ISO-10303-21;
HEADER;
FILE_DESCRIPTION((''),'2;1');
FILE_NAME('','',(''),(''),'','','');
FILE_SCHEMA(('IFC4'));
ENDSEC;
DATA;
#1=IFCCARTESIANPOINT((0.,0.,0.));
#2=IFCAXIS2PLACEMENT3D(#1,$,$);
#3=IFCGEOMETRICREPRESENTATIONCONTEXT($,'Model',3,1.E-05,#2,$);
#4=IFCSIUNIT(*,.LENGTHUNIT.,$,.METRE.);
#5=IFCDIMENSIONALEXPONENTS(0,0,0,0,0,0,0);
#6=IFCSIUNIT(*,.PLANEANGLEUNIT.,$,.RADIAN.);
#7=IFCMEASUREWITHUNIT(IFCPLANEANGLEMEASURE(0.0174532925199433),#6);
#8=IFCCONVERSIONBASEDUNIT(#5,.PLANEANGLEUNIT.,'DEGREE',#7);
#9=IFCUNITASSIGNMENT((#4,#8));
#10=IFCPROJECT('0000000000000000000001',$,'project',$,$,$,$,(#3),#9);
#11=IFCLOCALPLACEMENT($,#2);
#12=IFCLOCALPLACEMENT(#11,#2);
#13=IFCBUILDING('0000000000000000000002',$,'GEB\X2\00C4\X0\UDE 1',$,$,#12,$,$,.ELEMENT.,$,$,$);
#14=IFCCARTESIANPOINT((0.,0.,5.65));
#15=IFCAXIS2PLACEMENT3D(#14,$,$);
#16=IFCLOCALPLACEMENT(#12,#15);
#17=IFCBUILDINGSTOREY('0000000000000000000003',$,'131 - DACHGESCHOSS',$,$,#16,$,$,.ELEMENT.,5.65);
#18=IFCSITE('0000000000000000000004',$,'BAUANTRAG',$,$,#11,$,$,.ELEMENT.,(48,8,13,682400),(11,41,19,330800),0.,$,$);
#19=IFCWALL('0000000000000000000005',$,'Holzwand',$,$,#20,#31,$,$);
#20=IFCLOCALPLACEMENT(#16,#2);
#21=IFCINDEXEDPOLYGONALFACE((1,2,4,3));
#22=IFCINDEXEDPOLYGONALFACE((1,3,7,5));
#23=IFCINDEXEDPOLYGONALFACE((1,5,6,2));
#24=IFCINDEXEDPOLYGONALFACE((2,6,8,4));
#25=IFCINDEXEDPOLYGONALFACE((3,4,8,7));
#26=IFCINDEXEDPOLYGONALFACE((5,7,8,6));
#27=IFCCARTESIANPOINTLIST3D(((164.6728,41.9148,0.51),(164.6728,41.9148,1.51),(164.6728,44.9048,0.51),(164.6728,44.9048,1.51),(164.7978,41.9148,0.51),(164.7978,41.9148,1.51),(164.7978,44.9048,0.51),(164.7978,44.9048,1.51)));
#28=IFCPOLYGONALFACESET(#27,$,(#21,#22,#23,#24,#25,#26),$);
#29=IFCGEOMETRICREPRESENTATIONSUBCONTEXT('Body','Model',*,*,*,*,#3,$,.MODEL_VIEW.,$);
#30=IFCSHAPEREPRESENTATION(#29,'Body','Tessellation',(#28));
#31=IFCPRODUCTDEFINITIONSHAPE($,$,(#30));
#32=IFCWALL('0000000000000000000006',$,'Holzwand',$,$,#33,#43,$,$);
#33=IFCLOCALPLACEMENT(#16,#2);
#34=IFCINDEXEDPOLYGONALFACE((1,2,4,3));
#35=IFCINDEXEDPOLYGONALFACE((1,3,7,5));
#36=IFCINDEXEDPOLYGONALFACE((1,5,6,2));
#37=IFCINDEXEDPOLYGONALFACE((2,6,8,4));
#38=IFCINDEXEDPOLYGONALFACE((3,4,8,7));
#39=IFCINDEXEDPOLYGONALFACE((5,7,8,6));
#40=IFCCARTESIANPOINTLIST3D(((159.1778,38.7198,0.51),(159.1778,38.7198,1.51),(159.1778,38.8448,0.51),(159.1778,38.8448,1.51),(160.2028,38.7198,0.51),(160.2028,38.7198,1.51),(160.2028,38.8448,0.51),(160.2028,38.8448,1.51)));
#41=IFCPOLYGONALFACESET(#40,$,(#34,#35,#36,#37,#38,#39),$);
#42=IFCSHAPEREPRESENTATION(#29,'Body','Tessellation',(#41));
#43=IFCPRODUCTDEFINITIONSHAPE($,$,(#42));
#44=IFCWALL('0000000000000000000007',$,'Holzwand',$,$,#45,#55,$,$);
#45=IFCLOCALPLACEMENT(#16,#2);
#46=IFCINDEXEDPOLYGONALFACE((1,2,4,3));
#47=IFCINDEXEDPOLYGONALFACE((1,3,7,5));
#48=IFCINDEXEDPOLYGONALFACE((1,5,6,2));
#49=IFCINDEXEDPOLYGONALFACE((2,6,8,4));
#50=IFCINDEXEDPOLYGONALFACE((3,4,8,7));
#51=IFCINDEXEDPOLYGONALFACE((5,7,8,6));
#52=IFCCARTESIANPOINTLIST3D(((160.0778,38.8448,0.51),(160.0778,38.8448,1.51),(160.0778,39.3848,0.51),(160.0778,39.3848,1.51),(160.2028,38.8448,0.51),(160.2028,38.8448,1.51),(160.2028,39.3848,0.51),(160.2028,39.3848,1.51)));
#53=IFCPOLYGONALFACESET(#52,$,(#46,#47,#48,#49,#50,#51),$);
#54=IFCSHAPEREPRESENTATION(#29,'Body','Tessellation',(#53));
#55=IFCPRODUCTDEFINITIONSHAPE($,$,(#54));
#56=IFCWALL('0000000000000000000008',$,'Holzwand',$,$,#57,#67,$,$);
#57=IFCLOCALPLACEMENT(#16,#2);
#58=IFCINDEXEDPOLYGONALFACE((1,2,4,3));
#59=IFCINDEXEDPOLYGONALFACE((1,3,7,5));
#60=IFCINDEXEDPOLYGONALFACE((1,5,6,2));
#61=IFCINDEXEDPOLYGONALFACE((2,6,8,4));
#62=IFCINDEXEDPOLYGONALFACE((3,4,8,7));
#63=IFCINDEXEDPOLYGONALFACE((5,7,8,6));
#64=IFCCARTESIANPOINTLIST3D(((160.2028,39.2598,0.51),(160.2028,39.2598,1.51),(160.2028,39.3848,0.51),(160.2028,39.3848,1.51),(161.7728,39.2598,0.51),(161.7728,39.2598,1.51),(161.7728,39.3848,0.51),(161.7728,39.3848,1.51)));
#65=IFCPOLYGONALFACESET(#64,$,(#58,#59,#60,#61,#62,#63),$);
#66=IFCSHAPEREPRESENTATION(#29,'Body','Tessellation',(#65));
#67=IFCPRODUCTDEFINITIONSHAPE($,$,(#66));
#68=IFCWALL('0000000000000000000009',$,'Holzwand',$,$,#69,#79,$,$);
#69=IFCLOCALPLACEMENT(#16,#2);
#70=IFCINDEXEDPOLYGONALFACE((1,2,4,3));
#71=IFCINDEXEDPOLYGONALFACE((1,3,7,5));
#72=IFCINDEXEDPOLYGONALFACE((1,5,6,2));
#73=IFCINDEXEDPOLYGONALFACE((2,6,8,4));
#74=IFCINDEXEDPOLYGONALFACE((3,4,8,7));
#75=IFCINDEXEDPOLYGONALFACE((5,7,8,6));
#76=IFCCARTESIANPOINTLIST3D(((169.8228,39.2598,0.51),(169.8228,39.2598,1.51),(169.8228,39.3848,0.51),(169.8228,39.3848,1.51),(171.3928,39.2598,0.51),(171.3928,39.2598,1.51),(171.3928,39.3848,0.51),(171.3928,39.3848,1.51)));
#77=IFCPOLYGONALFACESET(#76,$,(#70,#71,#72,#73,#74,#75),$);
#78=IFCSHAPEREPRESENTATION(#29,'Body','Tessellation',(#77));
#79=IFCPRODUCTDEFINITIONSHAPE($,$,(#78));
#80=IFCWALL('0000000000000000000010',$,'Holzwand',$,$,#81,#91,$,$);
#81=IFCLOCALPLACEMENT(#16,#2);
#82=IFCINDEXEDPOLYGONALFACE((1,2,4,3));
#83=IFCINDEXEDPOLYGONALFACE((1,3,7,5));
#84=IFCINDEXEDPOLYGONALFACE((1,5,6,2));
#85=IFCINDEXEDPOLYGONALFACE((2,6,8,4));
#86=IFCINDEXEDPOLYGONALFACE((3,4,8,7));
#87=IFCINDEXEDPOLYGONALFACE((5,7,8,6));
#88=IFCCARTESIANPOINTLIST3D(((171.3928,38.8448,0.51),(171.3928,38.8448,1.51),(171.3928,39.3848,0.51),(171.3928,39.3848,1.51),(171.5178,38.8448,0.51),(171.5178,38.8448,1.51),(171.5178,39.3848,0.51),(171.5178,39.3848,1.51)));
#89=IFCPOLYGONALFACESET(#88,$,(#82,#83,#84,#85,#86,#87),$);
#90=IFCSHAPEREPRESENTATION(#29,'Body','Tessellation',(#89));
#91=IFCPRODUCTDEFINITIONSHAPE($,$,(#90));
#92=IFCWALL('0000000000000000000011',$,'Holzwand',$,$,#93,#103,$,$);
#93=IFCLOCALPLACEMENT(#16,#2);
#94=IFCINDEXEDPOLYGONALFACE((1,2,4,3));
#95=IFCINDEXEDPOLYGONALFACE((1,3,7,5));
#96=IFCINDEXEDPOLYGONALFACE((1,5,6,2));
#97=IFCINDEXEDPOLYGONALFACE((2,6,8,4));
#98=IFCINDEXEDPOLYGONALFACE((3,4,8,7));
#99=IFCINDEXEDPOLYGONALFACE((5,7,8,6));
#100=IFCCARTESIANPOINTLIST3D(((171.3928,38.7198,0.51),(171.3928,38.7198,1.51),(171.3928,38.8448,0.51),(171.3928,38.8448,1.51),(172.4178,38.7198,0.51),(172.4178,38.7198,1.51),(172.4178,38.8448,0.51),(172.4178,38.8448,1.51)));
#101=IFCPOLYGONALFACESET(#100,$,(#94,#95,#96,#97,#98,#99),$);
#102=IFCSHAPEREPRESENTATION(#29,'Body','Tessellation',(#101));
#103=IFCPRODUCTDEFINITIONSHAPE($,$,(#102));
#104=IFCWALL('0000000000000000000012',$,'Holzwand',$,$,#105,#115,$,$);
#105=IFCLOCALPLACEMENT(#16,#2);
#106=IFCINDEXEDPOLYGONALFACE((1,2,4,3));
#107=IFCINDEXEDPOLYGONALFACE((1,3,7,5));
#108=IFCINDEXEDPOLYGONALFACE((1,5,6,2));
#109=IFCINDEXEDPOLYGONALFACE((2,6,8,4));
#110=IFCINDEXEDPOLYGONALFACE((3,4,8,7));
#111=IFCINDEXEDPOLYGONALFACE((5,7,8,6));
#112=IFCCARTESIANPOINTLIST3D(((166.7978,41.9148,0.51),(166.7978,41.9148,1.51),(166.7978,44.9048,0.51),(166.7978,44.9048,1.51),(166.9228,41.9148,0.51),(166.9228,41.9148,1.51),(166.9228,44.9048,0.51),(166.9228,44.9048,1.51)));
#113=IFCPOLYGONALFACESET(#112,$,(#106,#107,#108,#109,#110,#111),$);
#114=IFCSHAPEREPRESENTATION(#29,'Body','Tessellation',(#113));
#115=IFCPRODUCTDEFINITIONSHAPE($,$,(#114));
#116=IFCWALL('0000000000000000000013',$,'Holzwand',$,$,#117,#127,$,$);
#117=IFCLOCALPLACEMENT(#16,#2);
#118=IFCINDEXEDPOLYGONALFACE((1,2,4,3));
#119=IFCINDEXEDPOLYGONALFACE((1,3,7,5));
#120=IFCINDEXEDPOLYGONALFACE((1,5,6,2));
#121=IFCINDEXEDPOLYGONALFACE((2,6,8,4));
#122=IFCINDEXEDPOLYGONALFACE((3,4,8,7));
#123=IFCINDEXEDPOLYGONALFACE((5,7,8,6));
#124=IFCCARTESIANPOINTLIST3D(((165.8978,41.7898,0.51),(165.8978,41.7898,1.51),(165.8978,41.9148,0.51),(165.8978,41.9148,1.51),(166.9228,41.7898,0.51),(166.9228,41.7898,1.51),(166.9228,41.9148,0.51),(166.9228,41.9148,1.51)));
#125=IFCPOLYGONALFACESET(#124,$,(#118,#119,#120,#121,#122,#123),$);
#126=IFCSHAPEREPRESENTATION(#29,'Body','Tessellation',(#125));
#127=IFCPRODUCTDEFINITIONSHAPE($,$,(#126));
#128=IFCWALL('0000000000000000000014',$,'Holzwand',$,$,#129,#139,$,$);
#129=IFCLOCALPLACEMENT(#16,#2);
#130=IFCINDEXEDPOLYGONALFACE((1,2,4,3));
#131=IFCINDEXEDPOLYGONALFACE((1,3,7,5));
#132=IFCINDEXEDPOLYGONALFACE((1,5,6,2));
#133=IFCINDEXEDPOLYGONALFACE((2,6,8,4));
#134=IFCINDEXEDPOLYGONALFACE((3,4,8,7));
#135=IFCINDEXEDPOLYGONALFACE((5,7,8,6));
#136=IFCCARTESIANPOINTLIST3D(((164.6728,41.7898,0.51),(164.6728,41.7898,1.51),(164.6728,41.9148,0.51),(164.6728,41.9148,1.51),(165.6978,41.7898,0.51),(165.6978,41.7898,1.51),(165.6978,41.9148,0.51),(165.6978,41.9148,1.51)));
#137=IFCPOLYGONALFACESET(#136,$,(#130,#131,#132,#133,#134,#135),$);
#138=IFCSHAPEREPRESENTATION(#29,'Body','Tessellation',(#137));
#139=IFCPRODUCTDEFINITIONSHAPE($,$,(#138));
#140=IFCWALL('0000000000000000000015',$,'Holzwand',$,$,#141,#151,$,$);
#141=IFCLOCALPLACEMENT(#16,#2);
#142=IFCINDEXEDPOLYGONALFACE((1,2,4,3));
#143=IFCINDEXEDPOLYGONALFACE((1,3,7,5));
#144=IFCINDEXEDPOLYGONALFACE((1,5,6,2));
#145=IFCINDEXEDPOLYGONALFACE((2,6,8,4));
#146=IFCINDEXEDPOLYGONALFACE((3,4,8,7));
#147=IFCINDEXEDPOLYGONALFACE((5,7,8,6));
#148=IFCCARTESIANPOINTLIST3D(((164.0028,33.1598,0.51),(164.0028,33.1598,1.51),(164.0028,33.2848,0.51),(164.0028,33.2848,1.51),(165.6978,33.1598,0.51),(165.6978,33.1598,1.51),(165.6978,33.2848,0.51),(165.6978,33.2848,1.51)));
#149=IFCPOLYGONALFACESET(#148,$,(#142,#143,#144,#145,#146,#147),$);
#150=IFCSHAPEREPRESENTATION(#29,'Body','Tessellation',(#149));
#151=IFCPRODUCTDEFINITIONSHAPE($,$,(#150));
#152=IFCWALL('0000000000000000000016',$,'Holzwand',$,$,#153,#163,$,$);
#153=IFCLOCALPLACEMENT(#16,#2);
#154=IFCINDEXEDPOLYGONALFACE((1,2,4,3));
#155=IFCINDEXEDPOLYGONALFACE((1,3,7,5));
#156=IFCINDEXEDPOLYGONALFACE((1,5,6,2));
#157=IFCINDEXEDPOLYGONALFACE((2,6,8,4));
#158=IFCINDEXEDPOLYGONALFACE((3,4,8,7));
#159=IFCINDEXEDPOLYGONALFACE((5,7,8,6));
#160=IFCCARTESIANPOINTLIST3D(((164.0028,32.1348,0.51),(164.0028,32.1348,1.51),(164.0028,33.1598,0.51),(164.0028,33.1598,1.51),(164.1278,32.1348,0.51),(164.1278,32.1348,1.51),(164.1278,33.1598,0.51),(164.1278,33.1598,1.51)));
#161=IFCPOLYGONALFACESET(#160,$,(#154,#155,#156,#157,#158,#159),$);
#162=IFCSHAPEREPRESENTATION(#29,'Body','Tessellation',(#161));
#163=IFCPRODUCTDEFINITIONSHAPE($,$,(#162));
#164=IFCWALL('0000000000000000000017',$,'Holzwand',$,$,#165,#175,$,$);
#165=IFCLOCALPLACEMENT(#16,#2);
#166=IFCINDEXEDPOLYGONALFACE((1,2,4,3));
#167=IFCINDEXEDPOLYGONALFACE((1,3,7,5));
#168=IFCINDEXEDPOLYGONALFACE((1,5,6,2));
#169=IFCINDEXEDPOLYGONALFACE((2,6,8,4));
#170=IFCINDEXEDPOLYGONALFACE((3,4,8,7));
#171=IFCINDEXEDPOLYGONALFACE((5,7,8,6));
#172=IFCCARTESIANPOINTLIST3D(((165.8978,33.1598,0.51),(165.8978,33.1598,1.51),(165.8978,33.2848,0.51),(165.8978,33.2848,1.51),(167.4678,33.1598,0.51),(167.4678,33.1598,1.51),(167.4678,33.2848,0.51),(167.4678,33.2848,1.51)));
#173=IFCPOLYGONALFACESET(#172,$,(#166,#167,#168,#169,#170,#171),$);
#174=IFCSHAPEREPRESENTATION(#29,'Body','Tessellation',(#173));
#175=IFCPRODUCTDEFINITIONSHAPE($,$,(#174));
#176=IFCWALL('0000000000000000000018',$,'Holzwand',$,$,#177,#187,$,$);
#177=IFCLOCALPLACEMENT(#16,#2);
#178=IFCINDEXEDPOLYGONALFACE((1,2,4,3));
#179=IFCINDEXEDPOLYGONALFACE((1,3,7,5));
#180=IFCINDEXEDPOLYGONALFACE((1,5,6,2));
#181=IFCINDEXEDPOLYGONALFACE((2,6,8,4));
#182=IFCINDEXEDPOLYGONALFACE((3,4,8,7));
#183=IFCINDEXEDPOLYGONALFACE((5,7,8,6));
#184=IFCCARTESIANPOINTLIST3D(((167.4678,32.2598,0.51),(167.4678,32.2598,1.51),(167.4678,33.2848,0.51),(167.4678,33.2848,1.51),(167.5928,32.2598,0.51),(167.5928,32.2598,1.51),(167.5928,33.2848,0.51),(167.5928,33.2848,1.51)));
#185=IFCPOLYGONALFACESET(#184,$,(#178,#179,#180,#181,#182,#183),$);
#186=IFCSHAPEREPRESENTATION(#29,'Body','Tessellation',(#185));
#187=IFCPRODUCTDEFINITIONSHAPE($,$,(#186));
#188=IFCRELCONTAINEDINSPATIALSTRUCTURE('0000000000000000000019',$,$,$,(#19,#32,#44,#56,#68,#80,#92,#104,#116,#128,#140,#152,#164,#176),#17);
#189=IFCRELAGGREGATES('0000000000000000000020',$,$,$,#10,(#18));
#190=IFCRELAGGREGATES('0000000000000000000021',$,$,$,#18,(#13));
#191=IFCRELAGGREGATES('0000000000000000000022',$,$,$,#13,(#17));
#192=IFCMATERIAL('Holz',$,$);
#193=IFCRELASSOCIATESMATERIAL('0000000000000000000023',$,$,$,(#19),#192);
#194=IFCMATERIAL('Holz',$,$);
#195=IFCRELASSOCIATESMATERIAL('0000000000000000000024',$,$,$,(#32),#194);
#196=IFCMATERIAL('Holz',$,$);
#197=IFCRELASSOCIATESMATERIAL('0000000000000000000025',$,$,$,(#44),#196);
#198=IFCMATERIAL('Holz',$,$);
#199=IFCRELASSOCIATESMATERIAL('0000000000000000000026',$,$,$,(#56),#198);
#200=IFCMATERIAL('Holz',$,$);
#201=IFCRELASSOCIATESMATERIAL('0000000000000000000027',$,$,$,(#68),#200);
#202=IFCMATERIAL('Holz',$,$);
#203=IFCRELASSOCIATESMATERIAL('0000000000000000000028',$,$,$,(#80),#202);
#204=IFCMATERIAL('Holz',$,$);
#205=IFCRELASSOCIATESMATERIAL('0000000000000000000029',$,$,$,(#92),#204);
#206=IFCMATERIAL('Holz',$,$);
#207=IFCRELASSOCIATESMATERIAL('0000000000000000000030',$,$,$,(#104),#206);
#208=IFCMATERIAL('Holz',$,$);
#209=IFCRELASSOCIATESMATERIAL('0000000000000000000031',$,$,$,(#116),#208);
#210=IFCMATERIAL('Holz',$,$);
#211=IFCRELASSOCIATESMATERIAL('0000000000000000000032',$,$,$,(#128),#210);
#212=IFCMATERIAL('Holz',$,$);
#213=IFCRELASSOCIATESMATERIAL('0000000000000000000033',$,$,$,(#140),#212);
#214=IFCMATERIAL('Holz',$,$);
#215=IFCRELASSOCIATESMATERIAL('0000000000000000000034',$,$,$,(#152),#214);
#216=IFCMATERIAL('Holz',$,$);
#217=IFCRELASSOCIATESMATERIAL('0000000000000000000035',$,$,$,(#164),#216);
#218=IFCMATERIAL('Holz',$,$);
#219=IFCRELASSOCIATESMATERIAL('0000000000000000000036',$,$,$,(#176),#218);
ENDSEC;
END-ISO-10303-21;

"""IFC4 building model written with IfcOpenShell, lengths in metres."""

from ifc_helpers import new_model, entity, si_unit, converted_unit, frame, origin, origin_with_axes, place, context, subcontext, project, spatial, indexed_curve, outline, extrude, material, element, save


model = new_model("IFC4")

# Units and contexts
model_context = context("Model", 3, precision=1e-05, world=origin())
body_context = subcontext(model_context, "Body", "Model", "MODEL_VIEW")
ifc_project = project(units=[si_unit("LENGTHUNIT", "METRE"), converted_unit("PLANEANGLEUNIT", "DEGREE", entity("IfcPlaneAngleMeasure", 0.0174532925199433), si_unit("PLANEANGLEUNIT", "RADIAN"), dimensions=[0, 0, 0, 0, 0, 0, 0])], contexts=[model_context])

# Site, building, storey
site_placement = place(None, origin())
site = spatial("IfcSite", under=ifc_project, at=site_placement, Name="BAUANTRAG", CompositionType="ELEMENT", RefLatitude=(48, 8, 13, 682400), RefLongitude=(11, 41, 19, 330800), RefElevation=0.0)
building_placement = place(site_placement, origin())
building = spatial("IfcBuilding", under=site, at=building_placement, Name="GEBÄUDE 1", CompositionType="ELEMENT")
storey_placement = place(building_placement, frame((0.0, 0.0, 5.65)))
storey = spatial("IfcBuildingStorey", under=building, at=storey_placement, Name="131 - DACHGESCHOSS", CompositionType="ELEMENT", Elevation=5.65)

# Walls
ifc_material_1 = material(Name="Holz")
wall_1_placement = place(storey_placement, frame((164.7978, 41.9148, 0.51), z_axis=(0.0, 0.0, 1.0), x_axis=(0.0, 1.0, 0.0)))
element("IfcWall", 1, at=wall_1_placement, inside=storey, material=ifc_material_1, Name="Holzwand", context=body_context, shape_type="SweptSolid", body=[
    extrude(outline(indexed_curve([(0.0, -0.125), (2.99, -0.125), (2.99, 0.0), (0.0, 0.0), (0.0, -0.125)], self_intersect=False)), frame((0.0, 0.125, 0.0), z_axis=(0.0, 0.0, 1.0), x_axis=(1.0, 0.0, 0.0)), (0.0, 0.0, 1.0), 1.0),
])
ifc_material_2 = material(Name="Holz")
wall_2_placement = place(storey_placement, frame((160.2028, 38.8448, 0.51), z_axis=(0.0, 0.0, 1.0), x_axis=(-1.0, 0.0, 0.0)))
element("IfcWall", 2, at=wall_2_placement, inside=storey, material=ifc_material_2, Name="Holzwand", context=body_context, shape_type="SweptSolid", body=[
    extrude(outline(indexed_curve([(-1.025, -0.125), (0.0, -0.125), (0.0, 0.0), (-1.025, 0.0), (-1.025, -0.125)], self_intersect=False)), frame((1.025, 0.125, 0.0), z_axis=(0.0, 0.0, 1.0), x_axis=(1.0, 0.0, 0.0)), (0.0, 0.0, 1.0), 1.0),
])
ifc_material_3 = material(Name="Holz")
wall_3_placement = place(storey_placement, frame((160.0778, 39.3848, 0.51), z_axis=(0.0, 0.0, 1.0), x_axis=(0.0, -1.0, 0.0)))
element("IfcWall", 3, at=wall_3_placement, inside=storey, material=ifc_material_3, Name="Holzwand", context=body_context, shape_type="SweptSolid", body=[
    extrude(outline(indexed_curve([(-0.54, 0.0), (0.0, 0.0), (0.0, 0.125), (-0.54, 0.125), (-0.54, 0.0)], self_intersect=False)), frame((0.54, 0.0, 0.0), z_axis=(0.0, 0.0, 1.0), x_axis=(1.0, 0.0, 0.0)), (0.0, 0.0, 1.0), 1.0),
])
ifc_material_4 = material(Name="Holz")
wall_4_placement = place(storey_placement, frame((161.7728, 39.3848, 0.51), z_axis=(0.0, 0.0, 1.0), x_axis=(-1.0, 0.0, 0.0)))
element("IfcWall", 4, at=wall_4_placement, inside=storey, material=ifc_material_4, Name="Holzwand", context=body_context, shape_type="SweptSolid", body=[
    extrude(outline(indexed_curve([(-1.57, -0.125), (0.0, -0.125), (0.0, 0.0), (-1.57, 0.0), (-1.57, -0.125)], self_intersect=False)), frame((1.57, 0.125, 0.0), z_axis=(0.0, 0.0, 1.0), x_axis=(1.0, 0.0, 0.0)), (0.0, 0.0, 1.0), 1.0),
])
ifc_material_5 = material(Name="Holz")
wall_5_placement = place(storey_placement, frame((171.3928, 39.3848, 0.51), z_axis=(0.0, 0.0, 1.0), x_axis=(-1.0, 0.0, 0.0)))
element("IfcWall", 5, at=wall_5_placement, inside=storey, material=ifc_material_5, Name="Holzwand", context=body_context, shape_type="SweptSolid", body=[
    extrude(outline(indexed_curve([(-1.57, -0.125), (0.0, -0.125), (0.0, 0.0), (-1.57, 0.0), (-1.57, -0.125)], self_intersect=False)), frame((1.57, 0.125, 0.0), z_axis=(0.0, 0.0, 1.0), x_axis=(1.0, 0.0, 0.0)), (0.0, 0.0, 1.0), 1.0),
])
ifc_material_6 = material(Name="Holz")
wall_6_placement = place(storey_placement, frame((171.5178, 38.8448, 0.51), z_axis=(0.0, 0.0, 1.0), x_axis=(0.0, 1.0, 0.0)))
element("IfcWall", 6, at=wall_6_placement, inside=storey, material=ifc_material_6, Name="Holzwand", context=body_context, shape_type="SweptSolid", body=[
    extrude(outline(indexed_curve([(0.0, -0.125), (0.54, -0.125), (0.54, 0.0), (0.0, 0.0), (0.0, -0.125)], self_intersect=False)), frame((0.0, 0.125, 0.0), z_axis=(0.0, 0.0, 1.0), x_axis=(1.0, 0.0, 0.0)), (0.0, 0.0, 1.0), 1.0),
])
ifc_material_7 = material(Name="Holz")
wall_7_placement = place(storey_placement, frame((172.4178, 38.8448, 0.51), z_axis=(0.0, 0.0, 1.0), x_axis=(-1.0, 0.0, 0.0)))
element("IfcWall", 7, at=wall_7_placement, inside=storey, material=ifc_material_7, Name="Holzwand", context=body_context, shape_type="SweptSolid", body=[
    extrude(outline(indexed_curve([(-1.025, -0.125), (0.0, -0.125), (0.0, 0.0), (-1.025, 0.0), (-1.025, -0.125)], self_intersect=False)), frame((1.025, 0.125, 0.0), z_axis=(0.0, 0.0, 1.0), x_axis=(1.0, 0.0, 0.0)), (0.0, 0.0, 1.0), 1.0),
])
ifc_material_8 = material(Name="Holz")
wall_8_placement = place(storey_placement, frame((166.7978, 44.9048, 0.51), z_axis=(0.0, 0.0, 1.0), x_axis=(0.0, -1.0, 0.0)))
element("IfcWall", 8, at=wall_8_placement, inside=storey, material=ifc_material_8, Name="Holzwand", context=body_context, shape_type="SweptSolid", body=[
    extrude(outline(indexed_curve([(-2.99, 0.0), (0.0, 0.0), (0.0, 0.125), (-2.99, 0.125), (-2.99, 0.0)], self_intersect=False)), frame((2.99, 0.0, 0.0), z_axis=(0.0, 0.0, 1.0), x_axis=(1.0, 0.0, 0.0)), (0.0, 0.0, 1.0), 1.0),
])
ifc_material_9 = material(Name="Holz")
wall_9_placement = place(storey_placement, frame((166.9228, 41.9148, 0.51), z_axis=(0.0, 0.0, 1.0), x_axis=(-1.0, 0.0, 0.0)))
element("IfcWall", 9, at=wall_9_placement, inside=storey, material=ifc_material_9, Name="Holzwand", context=body_context, shape_type="SweptSolid", body=[
    extrude(outline(indexed_curve([(-1.025, -0.125), (0.0, -0.125), (0.0, 0.0), (-1.025, 0.0), (-1.025, -0.125)], self_intersect=False)), frame((1.025, 0.125, 0.0), z_axis=(0.0, 0.0, 1.0), x_axis=(1.0, 0.0, 0.0)), (0.0, 0.0, 1.0), 1.0),
])
ifc_material_10 = material(Name="Holz")
wall_10_placement = place(storey_placement, frame((165.6978, 41.9148, 0.51), z_axis=(0.0, 0.0, 1.0), x_axis=(-1.0, 0.0, 0.0)))
element("IfcWall", 10, at=wall_10_placement, inside=storey, material=ifc_material_10, Name="Holzwand", context=body_context, shape_type="SweptSolid", body=[
    extrude(outline(indexed_curve([(-1.025, -0.125), (0.0, -0.125), (0.0, 0.0), (-1.025, 0.0), (-1.025, -0.125)], self_intersect=False)), frame((1.025, 0.125, 0.0), z_axis=(0.0, 0.0, 1.0), x_axis=(1.0, 0.0, 0.0)), (0.0, 0.0, 1.0), 1.0),
])
ifc_material_11 = material(Name="Holz")
wall_11_placement = place(storey_placement, frame((164.0028, 33.1598, 0.51)))
element("IfcWall", 11, at=wall_11_placement, inside=storey, material=ifc_material_11, Name="Holzwand", context=body_context, shape_type="SweptSolid", body=[
    extrude(outline(indexed_curve([(0.0, 0.0), (1.695, 0.0), (1.695, 0.125), (0.0, 0.125), (0.0, 0.0)], self_intersect=False)), origin_with_axes(), (0.0, 0.0, 1.0), 1.0),
])
ifc_material_12 = material(Name="Holz")
wall_12_placement = place(storey_placement, frame((164.1278, 32.1348, 0.51), z_axis=(0.0, 0.0, 1.0), x_axis=(0.0, 1.0, 0.0)))
element("IfcWall", 12, at=wall_12_placement, inside=storey, material=ifc_material_12, Name="Holzwand", context=body_context, shape_type="SweptSolid", body=[
    extrude(outline(indexed_curve([(0.0, -0.125), (1.025, -0.125), (1.025, 0.0), (0.0, 0.0), (0.0, -0.125)], self_intersect=False)), frame((0.0, 0.125, 0.0), z_axis=(0.0, 0.0, 1.0), x_axis=(1.0, 0.0, 0.0)), (0.0, 0.0, 1.0), 1.0),
])
ifc_material_13 = material(Name="Holz")
wall_13_placement = place(storey_placement, frame((165.8978, 33.1598, 0.51)))
element("IfcWall", 13, at=wall_13_placement, inside=storey, material=ifc_material_13, Name="Holzwand", context=body_context, shape_type="SweptSolid", body=[
    extrude(outline(indexed_curve([(0.0, 0.0), (1.57, 0.0), (1.57, 0.125), (0.0, 0.125), (0.0, 0.0)], self_intersect=False)), origin_with_axes(), (0.0, 0.0, 1.0), 1.0),
])
ifc_material_14 = material(Name="Holz")
wall_14_placement = place(storey_placement, frame((167.4678, 33.2848, 0.51), z_axis=(0.0, 0.0, 1.0), x_axis=(0.0, -1.0, 0.0)))
element("IfcWall", 14, at=wall_14_placement, inside=storey, material=ifc_material_14, Name="Holzwand", context=body_context, shape_type="SweptSolid", body=[
    extrude(outline(indexed_curve([(-1.025, 0.0), (0.0, 0.0), (0.0, 0.125), (-1.025, 0.125), (-1.025, 0.0)], self_intersect=False)), frame((1.025, 0.0, 0.0), z_axis=(0.0, 0.0, 1.0), x_axis=(1.0, 0.0, 0.0)), (0.0, 0.0, 1.0), 1.0),
])

save(model, "model.ifc")
